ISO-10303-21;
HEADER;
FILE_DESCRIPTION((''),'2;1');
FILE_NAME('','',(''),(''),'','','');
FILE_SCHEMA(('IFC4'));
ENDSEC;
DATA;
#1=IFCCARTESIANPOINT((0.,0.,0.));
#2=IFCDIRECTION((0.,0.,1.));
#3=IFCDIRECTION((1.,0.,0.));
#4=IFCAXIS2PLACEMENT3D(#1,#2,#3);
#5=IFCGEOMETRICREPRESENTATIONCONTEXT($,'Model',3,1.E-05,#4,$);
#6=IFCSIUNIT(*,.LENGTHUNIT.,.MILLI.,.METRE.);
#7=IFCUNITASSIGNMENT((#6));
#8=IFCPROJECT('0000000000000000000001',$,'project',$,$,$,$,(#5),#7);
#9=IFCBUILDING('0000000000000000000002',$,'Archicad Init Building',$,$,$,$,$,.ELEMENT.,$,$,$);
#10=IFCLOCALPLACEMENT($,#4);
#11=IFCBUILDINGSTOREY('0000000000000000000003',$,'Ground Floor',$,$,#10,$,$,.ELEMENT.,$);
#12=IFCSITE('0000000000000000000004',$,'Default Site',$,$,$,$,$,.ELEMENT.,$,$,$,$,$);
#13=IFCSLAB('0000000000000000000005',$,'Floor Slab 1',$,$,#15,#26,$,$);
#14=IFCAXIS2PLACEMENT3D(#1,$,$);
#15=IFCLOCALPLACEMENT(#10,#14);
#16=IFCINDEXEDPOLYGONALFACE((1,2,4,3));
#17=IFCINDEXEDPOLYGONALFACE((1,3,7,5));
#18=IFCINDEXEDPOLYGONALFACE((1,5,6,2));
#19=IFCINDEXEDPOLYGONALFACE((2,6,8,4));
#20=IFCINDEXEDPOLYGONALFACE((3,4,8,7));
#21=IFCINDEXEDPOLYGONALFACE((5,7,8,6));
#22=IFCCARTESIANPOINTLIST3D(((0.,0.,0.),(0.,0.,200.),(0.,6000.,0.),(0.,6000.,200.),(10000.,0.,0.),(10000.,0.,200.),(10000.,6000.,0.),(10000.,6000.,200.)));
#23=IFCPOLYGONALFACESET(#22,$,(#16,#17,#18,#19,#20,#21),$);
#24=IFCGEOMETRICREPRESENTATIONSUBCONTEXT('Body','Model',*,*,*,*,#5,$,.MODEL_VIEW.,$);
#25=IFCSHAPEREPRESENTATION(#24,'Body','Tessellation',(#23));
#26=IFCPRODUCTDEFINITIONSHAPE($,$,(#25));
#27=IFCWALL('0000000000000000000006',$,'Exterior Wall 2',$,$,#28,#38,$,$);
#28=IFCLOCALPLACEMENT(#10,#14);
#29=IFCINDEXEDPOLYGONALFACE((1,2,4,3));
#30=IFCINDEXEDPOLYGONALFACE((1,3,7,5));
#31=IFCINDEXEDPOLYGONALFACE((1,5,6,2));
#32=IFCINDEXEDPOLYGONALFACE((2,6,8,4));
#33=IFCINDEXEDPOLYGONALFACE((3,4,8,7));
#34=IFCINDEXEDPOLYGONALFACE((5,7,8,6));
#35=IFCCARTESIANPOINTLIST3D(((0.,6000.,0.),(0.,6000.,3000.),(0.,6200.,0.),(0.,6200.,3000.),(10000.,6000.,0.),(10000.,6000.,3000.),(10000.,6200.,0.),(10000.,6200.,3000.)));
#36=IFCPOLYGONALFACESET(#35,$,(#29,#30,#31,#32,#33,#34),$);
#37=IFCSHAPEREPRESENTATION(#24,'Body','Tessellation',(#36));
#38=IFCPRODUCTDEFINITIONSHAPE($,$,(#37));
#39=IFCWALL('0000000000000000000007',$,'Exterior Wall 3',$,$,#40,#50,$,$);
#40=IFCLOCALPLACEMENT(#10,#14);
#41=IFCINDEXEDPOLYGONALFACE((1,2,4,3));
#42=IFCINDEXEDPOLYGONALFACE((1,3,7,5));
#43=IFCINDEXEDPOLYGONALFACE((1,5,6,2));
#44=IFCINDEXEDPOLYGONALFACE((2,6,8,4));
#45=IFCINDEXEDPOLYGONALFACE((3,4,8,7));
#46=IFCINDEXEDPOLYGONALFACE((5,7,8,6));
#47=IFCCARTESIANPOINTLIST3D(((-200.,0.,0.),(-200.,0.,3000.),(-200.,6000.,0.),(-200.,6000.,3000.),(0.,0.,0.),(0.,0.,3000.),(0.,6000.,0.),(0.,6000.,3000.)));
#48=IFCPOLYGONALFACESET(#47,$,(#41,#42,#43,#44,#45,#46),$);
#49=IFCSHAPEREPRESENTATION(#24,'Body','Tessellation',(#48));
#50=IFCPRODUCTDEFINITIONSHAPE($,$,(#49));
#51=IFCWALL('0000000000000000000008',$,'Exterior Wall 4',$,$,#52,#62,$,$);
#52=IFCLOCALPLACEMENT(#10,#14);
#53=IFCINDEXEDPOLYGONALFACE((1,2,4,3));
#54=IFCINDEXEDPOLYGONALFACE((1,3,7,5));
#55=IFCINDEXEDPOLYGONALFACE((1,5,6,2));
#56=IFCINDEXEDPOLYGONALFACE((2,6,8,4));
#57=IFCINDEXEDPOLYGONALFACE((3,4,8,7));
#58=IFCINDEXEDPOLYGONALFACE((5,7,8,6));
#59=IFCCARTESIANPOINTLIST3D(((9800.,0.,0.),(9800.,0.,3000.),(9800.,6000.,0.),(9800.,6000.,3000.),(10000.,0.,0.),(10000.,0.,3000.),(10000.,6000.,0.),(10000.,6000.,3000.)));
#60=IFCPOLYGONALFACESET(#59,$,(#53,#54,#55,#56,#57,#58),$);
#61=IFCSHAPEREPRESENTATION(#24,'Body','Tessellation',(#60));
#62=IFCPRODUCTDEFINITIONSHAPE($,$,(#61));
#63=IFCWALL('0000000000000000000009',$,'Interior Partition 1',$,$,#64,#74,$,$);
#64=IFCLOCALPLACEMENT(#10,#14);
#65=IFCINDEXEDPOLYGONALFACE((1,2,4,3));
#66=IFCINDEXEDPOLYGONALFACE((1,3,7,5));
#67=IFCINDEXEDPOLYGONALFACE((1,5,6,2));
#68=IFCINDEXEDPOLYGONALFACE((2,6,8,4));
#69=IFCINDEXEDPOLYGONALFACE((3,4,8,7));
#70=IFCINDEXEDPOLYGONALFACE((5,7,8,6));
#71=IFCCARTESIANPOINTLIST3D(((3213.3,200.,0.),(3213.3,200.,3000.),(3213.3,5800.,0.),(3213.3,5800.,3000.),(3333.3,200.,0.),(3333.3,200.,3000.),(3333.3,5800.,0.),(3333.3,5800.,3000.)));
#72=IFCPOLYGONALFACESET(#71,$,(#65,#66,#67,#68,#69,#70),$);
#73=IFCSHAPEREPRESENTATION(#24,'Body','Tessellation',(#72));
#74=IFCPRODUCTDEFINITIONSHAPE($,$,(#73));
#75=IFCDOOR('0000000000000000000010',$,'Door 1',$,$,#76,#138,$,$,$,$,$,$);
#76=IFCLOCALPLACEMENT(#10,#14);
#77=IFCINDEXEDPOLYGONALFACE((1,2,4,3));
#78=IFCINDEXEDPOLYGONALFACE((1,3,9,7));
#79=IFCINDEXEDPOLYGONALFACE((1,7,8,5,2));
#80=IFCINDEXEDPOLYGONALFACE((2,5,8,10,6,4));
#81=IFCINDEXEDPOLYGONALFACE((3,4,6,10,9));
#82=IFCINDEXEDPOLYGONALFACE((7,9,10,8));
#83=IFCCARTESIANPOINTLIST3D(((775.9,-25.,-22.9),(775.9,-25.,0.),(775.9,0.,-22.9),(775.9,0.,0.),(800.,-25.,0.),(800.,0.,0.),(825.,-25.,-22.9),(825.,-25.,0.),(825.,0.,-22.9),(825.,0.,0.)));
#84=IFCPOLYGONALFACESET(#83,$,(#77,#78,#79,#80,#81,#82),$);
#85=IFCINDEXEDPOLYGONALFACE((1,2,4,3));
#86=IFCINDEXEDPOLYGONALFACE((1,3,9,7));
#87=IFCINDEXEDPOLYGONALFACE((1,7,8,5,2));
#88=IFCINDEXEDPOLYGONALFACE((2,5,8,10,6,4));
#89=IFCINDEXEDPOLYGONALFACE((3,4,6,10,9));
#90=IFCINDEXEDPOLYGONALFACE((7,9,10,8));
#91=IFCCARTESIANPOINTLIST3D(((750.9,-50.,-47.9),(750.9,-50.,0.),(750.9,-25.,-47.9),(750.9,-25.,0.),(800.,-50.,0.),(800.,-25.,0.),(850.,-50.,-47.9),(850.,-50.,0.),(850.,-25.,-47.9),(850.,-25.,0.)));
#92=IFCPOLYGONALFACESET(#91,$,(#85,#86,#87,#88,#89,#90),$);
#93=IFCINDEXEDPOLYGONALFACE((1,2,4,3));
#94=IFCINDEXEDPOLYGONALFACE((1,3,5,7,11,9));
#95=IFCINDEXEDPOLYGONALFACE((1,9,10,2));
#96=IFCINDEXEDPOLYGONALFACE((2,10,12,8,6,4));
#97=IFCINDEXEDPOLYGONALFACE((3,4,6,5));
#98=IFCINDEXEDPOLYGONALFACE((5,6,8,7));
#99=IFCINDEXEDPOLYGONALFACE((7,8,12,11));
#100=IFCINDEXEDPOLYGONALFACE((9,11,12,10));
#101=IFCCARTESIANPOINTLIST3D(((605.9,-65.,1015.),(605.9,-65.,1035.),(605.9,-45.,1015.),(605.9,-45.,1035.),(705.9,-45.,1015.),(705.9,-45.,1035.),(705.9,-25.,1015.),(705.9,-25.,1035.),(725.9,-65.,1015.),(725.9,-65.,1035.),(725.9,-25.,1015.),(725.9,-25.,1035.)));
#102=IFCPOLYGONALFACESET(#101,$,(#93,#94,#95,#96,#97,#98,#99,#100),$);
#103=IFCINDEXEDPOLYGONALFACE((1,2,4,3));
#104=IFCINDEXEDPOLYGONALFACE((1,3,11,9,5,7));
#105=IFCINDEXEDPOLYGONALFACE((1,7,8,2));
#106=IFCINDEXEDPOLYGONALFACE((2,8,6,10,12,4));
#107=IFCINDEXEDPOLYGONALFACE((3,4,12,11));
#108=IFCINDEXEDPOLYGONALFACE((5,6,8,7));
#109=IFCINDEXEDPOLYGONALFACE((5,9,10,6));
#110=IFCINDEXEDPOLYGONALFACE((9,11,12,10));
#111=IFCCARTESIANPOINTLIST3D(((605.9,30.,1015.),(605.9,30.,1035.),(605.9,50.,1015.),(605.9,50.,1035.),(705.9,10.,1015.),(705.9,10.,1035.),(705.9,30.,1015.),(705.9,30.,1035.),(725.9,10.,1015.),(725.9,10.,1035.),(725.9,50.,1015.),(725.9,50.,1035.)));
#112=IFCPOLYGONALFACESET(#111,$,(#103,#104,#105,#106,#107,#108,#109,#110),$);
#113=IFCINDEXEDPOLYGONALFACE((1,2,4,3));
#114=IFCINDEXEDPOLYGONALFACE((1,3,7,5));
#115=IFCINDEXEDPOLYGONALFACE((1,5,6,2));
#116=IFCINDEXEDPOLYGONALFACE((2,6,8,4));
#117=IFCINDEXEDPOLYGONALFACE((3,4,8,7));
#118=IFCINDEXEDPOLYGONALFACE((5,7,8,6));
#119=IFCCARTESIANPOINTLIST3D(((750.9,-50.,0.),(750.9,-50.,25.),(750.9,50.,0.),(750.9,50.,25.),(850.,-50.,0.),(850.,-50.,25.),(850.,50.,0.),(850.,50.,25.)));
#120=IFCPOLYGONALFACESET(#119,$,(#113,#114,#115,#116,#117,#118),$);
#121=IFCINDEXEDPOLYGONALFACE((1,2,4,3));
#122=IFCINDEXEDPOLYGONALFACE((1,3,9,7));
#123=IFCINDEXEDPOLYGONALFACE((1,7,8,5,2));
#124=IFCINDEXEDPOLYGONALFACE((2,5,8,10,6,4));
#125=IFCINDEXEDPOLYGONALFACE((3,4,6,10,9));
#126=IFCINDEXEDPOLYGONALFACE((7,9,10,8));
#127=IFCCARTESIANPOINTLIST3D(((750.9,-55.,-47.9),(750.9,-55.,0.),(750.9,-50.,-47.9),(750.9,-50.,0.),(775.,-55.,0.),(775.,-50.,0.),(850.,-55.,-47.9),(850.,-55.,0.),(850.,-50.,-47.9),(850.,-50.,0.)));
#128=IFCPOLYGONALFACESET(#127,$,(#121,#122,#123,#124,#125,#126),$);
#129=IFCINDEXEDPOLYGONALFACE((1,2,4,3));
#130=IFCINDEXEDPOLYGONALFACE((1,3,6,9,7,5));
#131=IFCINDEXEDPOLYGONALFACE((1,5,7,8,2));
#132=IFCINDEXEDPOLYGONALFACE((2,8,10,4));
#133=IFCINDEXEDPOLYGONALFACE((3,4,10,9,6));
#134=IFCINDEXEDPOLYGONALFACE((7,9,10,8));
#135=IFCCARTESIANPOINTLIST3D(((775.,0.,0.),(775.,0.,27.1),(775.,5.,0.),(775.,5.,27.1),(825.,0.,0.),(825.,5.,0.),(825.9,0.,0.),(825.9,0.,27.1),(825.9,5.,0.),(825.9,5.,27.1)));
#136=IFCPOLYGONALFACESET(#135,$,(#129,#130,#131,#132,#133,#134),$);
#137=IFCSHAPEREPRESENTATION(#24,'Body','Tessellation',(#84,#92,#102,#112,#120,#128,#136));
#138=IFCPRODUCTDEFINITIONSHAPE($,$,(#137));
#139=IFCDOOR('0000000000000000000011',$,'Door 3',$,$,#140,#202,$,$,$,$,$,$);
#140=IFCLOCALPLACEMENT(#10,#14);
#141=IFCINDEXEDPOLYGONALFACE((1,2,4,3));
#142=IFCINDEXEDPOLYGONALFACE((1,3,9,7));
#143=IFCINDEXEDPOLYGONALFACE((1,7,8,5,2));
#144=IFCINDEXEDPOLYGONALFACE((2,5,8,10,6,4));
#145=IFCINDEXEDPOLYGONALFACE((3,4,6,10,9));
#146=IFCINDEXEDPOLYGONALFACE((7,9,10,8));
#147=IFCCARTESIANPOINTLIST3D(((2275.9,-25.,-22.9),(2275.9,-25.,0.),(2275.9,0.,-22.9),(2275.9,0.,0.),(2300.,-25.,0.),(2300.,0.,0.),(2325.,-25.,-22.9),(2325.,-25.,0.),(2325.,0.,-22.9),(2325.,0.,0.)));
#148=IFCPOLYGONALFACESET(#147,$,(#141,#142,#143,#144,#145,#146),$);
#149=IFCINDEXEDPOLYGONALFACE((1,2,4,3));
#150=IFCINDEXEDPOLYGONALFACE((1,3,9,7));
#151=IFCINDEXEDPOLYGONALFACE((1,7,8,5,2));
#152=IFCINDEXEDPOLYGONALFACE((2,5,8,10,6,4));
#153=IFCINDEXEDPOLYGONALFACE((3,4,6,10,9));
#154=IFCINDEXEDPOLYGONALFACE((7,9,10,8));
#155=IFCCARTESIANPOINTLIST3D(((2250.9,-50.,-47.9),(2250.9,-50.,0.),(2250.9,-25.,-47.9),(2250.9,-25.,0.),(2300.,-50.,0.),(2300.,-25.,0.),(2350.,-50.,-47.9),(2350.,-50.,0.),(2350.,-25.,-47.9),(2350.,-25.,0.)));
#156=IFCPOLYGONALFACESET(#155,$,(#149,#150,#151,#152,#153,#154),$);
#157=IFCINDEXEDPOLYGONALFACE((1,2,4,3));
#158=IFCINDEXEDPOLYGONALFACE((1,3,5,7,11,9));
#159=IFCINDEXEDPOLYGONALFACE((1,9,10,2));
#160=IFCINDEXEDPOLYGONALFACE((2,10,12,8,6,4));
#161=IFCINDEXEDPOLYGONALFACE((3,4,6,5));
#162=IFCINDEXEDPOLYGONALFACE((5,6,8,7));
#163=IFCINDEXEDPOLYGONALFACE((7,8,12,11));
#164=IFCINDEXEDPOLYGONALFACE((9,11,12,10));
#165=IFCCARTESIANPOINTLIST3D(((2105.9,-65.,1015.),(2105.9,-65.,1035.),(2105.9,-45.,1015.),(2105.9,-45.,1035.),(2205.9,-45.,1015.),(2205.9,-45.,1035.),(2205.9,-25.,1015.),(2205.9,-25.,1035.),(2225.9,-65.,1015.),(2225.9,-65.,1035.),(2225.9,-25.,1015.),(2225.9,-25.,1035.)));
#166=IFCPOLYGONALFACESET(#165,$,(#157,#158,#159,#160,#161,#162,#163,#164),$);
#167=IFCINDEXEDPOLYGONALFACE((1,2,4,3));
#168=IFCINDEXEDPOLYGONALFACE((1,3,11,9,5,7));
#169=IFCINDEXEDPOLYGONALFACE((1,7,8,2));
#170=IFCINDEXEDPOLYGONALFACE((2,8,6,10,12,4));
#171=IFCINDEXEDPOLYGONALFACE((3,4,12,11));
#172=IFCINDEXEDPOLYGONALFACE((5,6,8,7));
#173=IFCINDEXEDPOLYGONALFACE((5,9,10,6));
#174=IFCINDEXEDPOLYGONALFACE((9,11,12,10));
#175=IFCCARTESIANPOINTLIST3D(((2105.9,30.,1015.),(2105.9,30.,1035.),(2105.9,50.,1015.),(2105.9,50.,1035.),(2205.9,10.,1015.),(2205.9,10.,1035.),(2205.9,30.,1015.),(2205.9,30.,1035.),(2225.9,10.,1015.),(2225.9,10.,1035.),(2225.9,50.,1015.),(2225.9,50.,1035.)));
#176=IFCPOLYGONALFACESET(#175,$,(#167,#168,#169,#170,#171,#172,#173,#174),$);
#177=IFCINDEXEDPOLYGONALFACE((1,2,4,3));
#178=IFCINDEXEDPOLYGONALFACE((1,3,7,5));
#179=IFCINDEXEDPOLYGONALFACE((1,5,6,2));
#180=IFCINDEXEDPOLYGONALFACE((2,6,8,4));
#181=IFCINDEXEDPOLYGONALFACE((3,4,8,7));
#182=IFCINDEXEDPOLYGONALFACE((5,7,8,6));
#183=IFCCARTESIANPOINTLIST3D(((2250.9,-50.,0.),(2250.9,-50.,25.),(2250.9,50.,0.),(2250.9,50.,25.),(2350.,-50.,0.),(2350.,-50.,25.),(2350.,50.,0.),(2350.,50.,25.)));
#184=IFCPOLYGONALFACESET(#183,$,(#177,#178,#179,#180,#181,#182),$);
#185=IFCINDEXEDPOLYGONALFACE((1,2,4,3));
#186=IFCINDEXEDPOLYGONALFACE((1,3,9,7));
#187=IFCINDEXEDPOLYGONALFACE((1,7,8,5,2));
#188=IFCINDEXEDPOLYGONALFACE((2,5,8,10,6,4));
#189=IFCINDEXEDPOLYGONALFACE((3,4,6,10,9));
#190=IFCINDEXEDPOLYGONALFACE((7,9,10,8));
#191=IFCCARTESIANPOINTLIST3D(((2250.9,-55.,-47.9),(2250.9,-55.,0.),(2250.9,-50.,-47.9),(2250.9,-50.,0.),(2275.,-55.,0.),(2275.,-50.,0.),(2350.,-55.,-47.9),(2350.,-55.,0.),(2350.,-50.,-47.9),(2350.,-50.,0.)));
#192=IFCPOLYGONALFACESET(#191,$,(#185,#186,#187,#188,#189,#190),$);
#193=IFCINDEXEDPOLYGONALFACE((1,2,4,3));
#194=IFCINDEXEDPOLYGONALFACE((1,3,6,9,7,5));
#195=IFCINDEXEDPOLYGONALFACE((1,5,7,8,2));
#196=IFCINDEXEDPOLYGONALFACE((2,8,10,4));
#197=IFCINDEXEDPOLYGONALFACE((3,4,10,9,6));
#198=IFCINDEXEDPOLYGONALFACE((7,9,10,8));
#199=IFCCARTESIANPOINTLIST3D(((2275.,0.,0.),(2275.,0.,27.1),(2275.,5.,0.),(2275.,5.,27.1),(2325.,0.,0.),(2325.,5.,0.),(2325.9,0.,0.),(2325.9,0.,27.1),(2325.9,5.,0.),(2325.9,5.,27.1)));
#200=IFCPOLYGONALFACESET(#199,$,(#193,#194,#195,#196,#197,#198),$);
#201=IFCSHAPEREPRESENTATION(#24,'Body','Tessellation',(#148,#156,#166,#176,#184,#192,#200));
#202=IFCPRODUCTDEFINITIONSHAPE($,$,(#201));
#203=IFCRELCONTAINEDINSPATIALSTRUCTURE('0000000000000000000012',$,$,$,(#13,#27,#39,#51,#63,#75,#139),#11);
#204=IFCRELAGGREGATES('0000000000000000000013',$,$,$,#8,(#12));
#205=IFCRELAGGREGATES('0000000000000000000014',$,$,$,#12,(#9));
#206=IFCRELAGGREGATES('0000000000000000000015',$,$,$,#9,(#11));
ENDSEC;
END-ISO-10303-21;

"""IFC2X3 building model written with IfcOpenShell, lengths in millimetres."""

from ifc_helpers import new_model, si_unit, frame, origin_with_axes, place, context, subcontext, project, spatial, polyline, outline, extrude, element, save


model = new_model("IFC2X3")

# Units and contexts
model_context = context("Model", 3, precision=1e-05, world=origin_with_axes())
body_context = subcontext(model_context, "Body", "Model", "MODEL_VIEW")
ifc_project = project(units=[si_unit("LENGTHUNIT", "METRE", prefix="MILLI")], contexts=[model_context])

# Site, building, storey
site = spatial("IfcSite", under=ifc_project, Name="Default Site", CompositionType="ELEMENT")
building = spatial("IfcBuilding", under=site, Name="Archicad Init Building", CompositionType="ELEMENT")
storey_placement = place(None, origin_with_axes())
storey = spatial("IfcBuildingStorey", under=building, at=storey_placement, Name="Ground Floor", CompositionType="ELEMENT")

# Slab
slab_placement = place(storey_placement, origin_with_axes())
element("IfcSlab", 1, at=slab_placement, inside=storey, Name="Floor Slab 1", context=body_context, shape_type="SweptSolid", body=[
    extrude(outline(polyline([(0.0, 0.0), (10000.0, 0.0), (10000.0, 6000.0), (0.0, 6000.0), (0.0, 0.0)])), origin_with_axes(), (0.0, 0.0, 1.0), 200.0),
])

# Walls
wall_1_placement = place(storey_placement, frame((0.0, 6000.0, 0.0), z_axis=(0.0, 0.0, 1.0), x_axis=(1.0, 0.0, 0.0)))
element("IfcWall", 2, at=wall_1_placement, inside=storey, Name="Exterior Wall 2", context=body_context, shape_type="SweptSolid", body=[
    extrude(outline(polyline([(0.0, 0.0), (0.0, 200.0), (10000.0, 200.0), (10000.0, 0.0), (0.0, 0.0)])), origin_with_axes(), (0.0, 0.0, 1.0), 3000.0),
])
for number, where, z_axis, x_axis, name in (
    (3, (0.0, 0.0, 0.0), (0.0, 0.0, 1.0), (0.0, 1.0, 0.0), "Exterior Wall 3"),
    (4, (10000.0, 0.0, 0.0), (0.0, 0.0, 1.0), (0.0, 1.0, 0.0), "Exterior Wall 4"),
):
    element("IfcWall", number, at=place(storey_placement, frame(where, z_axis=z_axis, x_axis=x_axis)), inside=storey, Name=name, context=body_context, shape_type="SweptSolid", body=[
        extrude(outline(polyline([(0.0, 0.0), (0.0, 200.0), (6000.0, 200.0), (6000.0, 0.0), (0.0, 0.0)])), origin_with_axes(), (0.0, 0.0, 1.0), 3000.0),
    ])
wall_2_placement = place(storey_placement, frame((3333.3, 200.0, 0.0), z_axis=(0.0, 0.0, 1.0), x_axis=(0.0, 1.0, 0.0)))
element("IfcWall", 5, at=wall_2_placement, inside=storey, Name="Interior Partition 1", context=body_context, shape_type="SweptSolid", body=[
    extrude(outline(polyline([(0.0, 0.0), (0.0, 120.0), (5600.0, 120.0), (5600.0, 0.0), (0.0, 0.0)])), origin_with_axes(), (0.0, 0.0, 1.0), 3000.0),
])

# Doors
door_1_placement = place(storey_placement, frame((800.0, -50.0, 0.0), z_axis=(0.0, 0.0, 1.0), x_axis=(1.0, 0.0, 0.0)))
element("IfcDoor", 6, at=door_1_placement, inside=storey, Name="Door 1", context=body_context, shape_type="SweptSolid", body=[
    extrude(outline(polyline([(0.0, 0.0), (0.0, 2.1), (0.9, 2.1), (0.9, 0.0), (-24.1, 0.0), (-24.1, -22.9), (25.0, -22.9), (25.0, 0.0), (0.0, 0.0)])), frame((0.0, 25.0, 0.0), z_axis=(0.0, -1.0, 0.0), x_axis=(1.0, 0.0, 0.0)), (0.0, 0.0, -1.0), 25.0),
    extrude(outline(polyline([(0.0, 0.0), (0.0, 2.1), (0.9, 2.1), (0.9, 0.0), (-49.1, 0.0), (-49.1, -47.9), (50.0, -47.9), (50.0, 0.0), (0.0, 0.0)])), frame((0.0, 0.0, 0.0), z_axis=(0.0, -1.0, 0.0), x_axis=(1.0, 0.0, 0.0)), (0.0, 0.0, -1.0), 25.0),
    extrude(outline(polyline([(0.0, 0.0), (-49.1, 0.0), (-49.1, 35.0), (0.0, 35.0), (0.0, 0.0)])), frame((25.0, 25.0, 25.0), z_axis=(0.0, 0.0, 1.0), x_axis=(1.0, 0.0, 0.0)), (0.0, 0.0, 1.0), -47.9),
    extrude(outline(polyline([(0.0, 0.0), (0.0, -40.0), (-120.0, -40.0), (-120.0, -20.0), (-20.0, -20.0), (-20.0, 0.0), (0.0, 0.0)])), frame((-74.1, 25.0, 1015.0), z_axis=(0.0, 0.0, 1.0), x_axis=(1.0, 0.0, 0.0)), (0.0, 0.0, 1.0), 20.0),
    extrude(outline(polyline([(0.0, 0.0), (0.0, 40.0), (-120.0, 40.0), (-120.0, 20.0), (-20.0, 20.0), (-20.0, 0.0), (0.0, 0.0)])), frame((-74.1, 60.0, 1015.0), z_axis=(0.0, 0.0, 1.0), x_axis=(1.0, 0.0, 0.0)), (0.0, 0.0, 1.0), 20.0),
    extrude(outline(polyline([(0.0, 0.0), (-99.1, 0.0), (-99.1, 100.0), (0.0, 100.0), (0.0, 0.0)])), frame((50.0, 0.0, 0.0), z_axis=(0.0, 0.0, 1.0), x_axis=(1.0, 0.0, 0.0)), (0.0, 0.0, 1.0), 25.0),
    extrude(outline(polyline([(0.0, 0.0), (0.0, 27.1), (50.9, 27.1), (50.9, 0.0), (-24.1, 0.0), (-24.1, -47.9), (75.0, -47.9), (75.0, 0.0), (0.0, 0.0)])), frame((-25.0, -5.0, 0.0), z_axis=(0.0, -1.0, 0.0), x_axis=(1.0, 0.0, 0.0)), (0.0, 0.0, -1.0), 5.0),
    extrude(outline(polyline([(0.0, 0.0), (0.0, 27.1), (50.9, 27.1), (50.9, 0.0), (0.9, 0.0), (0.9, -22.9), (50.0, -22.9), (50.0, 0.0), (0.0, 0.0)])), frame((-25.0, 50.0, 0.0), z_axis=(0.0, -1.0, 0.0), x_axis=(1.0, 0.0, 0.0)), (0.0, 0.0, -1.0), 5.0),
])
door_2_placement = place(storey_placement, frame((2300.0, -50.0, 0.0), z_axis=(0.0, 0.0, 1.0), x_axis=(1.0, 0.0, 0.0)))
element("IfcDoor", 7, at=door_2_placement, inside=storey, Name="Door 3", context=body_context, shape_type="SweptSolid", body=[
    extrude(outline(polyline([(0.0, 0.0), (0.0, 2.1), (0.9, 2.1), (0.9, 0.0), (-24.1, 0.0), (-24.1, -22.9), (25.0, -22.9), (25.0, 0.0), (0.0, 0.0)])), frame((0.0, 25.0, 0.0), z_axis=(0.0, -1.0, 0.0), x_axis=(1.0, 0.0, 0.0)), (0.0, 0.0, -1.0), 25.0),
    extrude(outline(polyline([(0.0, 0.0), (0.0, 2.1), (0.9, 2.1), (0.9, 0.0), (-49.1, 0.0), (-49.1, -47.9), (50.0, -47.9), (50.0, 0.0), (0.0, 0.0)])), frame((0.0, 0.0, 0.0), z_axis=(0.0, -1.0, 0.0), x_axis=(1.0, 0.0, 0.0)), (0.0, 0.0, -1.0), 25.0),
    extrude(outline(polyline([(0.0, 0.0), (-49.1, 0.0), (-49.1, 35.0), (0.0, 35.0), (0.0, 0.0)])), frame((25.0, 25.0, 25.0), z_axis=(0.0, 0.0, 1.0), x_axis=(1.0, 0.0, 0.0)), (0.0, 0.0, 1.0), -47.9),
    extrude(outline(polyline([(0.0, 0.0), (0.0, -40.0), (-120.0, -40.0), (-120.0, -20.0), (-20.0, -20.0), (-20.0, 0.0), (0.0, 0.0)])), frame((-74.1, 25.0, 1015.0), z_axis=(0.0, 0.0, 1.0), x_axis=(1.0, 0.0, 0.0)), (0.0, 0.0, 1.0), 20.0),
    extrude(outline(polyline([(0.0, 0.0), (0.0, 40.0), (-120.0, 40.0), (-120.0, 20.0), (-20.0, 20.0), (-20.0, 0.0), (0.0, 0.0)])), frame((-74.1, 60.0, 1015.0), z_axis=(0.0, 0.0, 1.0), x_axis=(1.0, 0.0, 0.0)), (0.0, 0.0, 1.0), 20.0),
    extrude(outline(polyline([(0.0, 0.0), (-99.1, 0.0), (-99.1, 100.0), (0.0, 100.0), (0.0, 0.0)])), frame((50.0, 0.0, 0.0), z_axis=(0.0, 0.0, 1.0), x_axis=(1.0, 0.0, 0.0)), (0.0, 0.0, 1.0), 25.0),
    extrude(outline(polyline([(0.0, 0.0), (0.0, 27.1), (50.9, 27.1), (50.9, 0.0), (-24.1, 0.0), (-24.1, -47.9), (75.0, -47.9), (75.0, 0.0), (0.0, 0.0)])), frame((-25.0, -5.0, 0.0), z_axis=(0.0, -1.0, 0.0), x_axis=(1.0, 0.0, 0.0)), (0.0, 0.0, -1.0), 5.0),
    extrude(outline(polyline([(0.0, 0.0), (0.0, 27.1), (50.9, 27.1), (50.9, 0.0), (0.9, 0.0), (0.9, -22.9), (50.0, -22.9), (50.0, 0.0), (0.0, 0.0)])), frame((-25.0, 50.0, 0.0), z_axis=(0.0, -1.0, 0.0), x_axis=(1.0, 0.0, 0.0)), (0.0, 0.0, -1.0), 5.0),
])

save(model, "model.ifc")
